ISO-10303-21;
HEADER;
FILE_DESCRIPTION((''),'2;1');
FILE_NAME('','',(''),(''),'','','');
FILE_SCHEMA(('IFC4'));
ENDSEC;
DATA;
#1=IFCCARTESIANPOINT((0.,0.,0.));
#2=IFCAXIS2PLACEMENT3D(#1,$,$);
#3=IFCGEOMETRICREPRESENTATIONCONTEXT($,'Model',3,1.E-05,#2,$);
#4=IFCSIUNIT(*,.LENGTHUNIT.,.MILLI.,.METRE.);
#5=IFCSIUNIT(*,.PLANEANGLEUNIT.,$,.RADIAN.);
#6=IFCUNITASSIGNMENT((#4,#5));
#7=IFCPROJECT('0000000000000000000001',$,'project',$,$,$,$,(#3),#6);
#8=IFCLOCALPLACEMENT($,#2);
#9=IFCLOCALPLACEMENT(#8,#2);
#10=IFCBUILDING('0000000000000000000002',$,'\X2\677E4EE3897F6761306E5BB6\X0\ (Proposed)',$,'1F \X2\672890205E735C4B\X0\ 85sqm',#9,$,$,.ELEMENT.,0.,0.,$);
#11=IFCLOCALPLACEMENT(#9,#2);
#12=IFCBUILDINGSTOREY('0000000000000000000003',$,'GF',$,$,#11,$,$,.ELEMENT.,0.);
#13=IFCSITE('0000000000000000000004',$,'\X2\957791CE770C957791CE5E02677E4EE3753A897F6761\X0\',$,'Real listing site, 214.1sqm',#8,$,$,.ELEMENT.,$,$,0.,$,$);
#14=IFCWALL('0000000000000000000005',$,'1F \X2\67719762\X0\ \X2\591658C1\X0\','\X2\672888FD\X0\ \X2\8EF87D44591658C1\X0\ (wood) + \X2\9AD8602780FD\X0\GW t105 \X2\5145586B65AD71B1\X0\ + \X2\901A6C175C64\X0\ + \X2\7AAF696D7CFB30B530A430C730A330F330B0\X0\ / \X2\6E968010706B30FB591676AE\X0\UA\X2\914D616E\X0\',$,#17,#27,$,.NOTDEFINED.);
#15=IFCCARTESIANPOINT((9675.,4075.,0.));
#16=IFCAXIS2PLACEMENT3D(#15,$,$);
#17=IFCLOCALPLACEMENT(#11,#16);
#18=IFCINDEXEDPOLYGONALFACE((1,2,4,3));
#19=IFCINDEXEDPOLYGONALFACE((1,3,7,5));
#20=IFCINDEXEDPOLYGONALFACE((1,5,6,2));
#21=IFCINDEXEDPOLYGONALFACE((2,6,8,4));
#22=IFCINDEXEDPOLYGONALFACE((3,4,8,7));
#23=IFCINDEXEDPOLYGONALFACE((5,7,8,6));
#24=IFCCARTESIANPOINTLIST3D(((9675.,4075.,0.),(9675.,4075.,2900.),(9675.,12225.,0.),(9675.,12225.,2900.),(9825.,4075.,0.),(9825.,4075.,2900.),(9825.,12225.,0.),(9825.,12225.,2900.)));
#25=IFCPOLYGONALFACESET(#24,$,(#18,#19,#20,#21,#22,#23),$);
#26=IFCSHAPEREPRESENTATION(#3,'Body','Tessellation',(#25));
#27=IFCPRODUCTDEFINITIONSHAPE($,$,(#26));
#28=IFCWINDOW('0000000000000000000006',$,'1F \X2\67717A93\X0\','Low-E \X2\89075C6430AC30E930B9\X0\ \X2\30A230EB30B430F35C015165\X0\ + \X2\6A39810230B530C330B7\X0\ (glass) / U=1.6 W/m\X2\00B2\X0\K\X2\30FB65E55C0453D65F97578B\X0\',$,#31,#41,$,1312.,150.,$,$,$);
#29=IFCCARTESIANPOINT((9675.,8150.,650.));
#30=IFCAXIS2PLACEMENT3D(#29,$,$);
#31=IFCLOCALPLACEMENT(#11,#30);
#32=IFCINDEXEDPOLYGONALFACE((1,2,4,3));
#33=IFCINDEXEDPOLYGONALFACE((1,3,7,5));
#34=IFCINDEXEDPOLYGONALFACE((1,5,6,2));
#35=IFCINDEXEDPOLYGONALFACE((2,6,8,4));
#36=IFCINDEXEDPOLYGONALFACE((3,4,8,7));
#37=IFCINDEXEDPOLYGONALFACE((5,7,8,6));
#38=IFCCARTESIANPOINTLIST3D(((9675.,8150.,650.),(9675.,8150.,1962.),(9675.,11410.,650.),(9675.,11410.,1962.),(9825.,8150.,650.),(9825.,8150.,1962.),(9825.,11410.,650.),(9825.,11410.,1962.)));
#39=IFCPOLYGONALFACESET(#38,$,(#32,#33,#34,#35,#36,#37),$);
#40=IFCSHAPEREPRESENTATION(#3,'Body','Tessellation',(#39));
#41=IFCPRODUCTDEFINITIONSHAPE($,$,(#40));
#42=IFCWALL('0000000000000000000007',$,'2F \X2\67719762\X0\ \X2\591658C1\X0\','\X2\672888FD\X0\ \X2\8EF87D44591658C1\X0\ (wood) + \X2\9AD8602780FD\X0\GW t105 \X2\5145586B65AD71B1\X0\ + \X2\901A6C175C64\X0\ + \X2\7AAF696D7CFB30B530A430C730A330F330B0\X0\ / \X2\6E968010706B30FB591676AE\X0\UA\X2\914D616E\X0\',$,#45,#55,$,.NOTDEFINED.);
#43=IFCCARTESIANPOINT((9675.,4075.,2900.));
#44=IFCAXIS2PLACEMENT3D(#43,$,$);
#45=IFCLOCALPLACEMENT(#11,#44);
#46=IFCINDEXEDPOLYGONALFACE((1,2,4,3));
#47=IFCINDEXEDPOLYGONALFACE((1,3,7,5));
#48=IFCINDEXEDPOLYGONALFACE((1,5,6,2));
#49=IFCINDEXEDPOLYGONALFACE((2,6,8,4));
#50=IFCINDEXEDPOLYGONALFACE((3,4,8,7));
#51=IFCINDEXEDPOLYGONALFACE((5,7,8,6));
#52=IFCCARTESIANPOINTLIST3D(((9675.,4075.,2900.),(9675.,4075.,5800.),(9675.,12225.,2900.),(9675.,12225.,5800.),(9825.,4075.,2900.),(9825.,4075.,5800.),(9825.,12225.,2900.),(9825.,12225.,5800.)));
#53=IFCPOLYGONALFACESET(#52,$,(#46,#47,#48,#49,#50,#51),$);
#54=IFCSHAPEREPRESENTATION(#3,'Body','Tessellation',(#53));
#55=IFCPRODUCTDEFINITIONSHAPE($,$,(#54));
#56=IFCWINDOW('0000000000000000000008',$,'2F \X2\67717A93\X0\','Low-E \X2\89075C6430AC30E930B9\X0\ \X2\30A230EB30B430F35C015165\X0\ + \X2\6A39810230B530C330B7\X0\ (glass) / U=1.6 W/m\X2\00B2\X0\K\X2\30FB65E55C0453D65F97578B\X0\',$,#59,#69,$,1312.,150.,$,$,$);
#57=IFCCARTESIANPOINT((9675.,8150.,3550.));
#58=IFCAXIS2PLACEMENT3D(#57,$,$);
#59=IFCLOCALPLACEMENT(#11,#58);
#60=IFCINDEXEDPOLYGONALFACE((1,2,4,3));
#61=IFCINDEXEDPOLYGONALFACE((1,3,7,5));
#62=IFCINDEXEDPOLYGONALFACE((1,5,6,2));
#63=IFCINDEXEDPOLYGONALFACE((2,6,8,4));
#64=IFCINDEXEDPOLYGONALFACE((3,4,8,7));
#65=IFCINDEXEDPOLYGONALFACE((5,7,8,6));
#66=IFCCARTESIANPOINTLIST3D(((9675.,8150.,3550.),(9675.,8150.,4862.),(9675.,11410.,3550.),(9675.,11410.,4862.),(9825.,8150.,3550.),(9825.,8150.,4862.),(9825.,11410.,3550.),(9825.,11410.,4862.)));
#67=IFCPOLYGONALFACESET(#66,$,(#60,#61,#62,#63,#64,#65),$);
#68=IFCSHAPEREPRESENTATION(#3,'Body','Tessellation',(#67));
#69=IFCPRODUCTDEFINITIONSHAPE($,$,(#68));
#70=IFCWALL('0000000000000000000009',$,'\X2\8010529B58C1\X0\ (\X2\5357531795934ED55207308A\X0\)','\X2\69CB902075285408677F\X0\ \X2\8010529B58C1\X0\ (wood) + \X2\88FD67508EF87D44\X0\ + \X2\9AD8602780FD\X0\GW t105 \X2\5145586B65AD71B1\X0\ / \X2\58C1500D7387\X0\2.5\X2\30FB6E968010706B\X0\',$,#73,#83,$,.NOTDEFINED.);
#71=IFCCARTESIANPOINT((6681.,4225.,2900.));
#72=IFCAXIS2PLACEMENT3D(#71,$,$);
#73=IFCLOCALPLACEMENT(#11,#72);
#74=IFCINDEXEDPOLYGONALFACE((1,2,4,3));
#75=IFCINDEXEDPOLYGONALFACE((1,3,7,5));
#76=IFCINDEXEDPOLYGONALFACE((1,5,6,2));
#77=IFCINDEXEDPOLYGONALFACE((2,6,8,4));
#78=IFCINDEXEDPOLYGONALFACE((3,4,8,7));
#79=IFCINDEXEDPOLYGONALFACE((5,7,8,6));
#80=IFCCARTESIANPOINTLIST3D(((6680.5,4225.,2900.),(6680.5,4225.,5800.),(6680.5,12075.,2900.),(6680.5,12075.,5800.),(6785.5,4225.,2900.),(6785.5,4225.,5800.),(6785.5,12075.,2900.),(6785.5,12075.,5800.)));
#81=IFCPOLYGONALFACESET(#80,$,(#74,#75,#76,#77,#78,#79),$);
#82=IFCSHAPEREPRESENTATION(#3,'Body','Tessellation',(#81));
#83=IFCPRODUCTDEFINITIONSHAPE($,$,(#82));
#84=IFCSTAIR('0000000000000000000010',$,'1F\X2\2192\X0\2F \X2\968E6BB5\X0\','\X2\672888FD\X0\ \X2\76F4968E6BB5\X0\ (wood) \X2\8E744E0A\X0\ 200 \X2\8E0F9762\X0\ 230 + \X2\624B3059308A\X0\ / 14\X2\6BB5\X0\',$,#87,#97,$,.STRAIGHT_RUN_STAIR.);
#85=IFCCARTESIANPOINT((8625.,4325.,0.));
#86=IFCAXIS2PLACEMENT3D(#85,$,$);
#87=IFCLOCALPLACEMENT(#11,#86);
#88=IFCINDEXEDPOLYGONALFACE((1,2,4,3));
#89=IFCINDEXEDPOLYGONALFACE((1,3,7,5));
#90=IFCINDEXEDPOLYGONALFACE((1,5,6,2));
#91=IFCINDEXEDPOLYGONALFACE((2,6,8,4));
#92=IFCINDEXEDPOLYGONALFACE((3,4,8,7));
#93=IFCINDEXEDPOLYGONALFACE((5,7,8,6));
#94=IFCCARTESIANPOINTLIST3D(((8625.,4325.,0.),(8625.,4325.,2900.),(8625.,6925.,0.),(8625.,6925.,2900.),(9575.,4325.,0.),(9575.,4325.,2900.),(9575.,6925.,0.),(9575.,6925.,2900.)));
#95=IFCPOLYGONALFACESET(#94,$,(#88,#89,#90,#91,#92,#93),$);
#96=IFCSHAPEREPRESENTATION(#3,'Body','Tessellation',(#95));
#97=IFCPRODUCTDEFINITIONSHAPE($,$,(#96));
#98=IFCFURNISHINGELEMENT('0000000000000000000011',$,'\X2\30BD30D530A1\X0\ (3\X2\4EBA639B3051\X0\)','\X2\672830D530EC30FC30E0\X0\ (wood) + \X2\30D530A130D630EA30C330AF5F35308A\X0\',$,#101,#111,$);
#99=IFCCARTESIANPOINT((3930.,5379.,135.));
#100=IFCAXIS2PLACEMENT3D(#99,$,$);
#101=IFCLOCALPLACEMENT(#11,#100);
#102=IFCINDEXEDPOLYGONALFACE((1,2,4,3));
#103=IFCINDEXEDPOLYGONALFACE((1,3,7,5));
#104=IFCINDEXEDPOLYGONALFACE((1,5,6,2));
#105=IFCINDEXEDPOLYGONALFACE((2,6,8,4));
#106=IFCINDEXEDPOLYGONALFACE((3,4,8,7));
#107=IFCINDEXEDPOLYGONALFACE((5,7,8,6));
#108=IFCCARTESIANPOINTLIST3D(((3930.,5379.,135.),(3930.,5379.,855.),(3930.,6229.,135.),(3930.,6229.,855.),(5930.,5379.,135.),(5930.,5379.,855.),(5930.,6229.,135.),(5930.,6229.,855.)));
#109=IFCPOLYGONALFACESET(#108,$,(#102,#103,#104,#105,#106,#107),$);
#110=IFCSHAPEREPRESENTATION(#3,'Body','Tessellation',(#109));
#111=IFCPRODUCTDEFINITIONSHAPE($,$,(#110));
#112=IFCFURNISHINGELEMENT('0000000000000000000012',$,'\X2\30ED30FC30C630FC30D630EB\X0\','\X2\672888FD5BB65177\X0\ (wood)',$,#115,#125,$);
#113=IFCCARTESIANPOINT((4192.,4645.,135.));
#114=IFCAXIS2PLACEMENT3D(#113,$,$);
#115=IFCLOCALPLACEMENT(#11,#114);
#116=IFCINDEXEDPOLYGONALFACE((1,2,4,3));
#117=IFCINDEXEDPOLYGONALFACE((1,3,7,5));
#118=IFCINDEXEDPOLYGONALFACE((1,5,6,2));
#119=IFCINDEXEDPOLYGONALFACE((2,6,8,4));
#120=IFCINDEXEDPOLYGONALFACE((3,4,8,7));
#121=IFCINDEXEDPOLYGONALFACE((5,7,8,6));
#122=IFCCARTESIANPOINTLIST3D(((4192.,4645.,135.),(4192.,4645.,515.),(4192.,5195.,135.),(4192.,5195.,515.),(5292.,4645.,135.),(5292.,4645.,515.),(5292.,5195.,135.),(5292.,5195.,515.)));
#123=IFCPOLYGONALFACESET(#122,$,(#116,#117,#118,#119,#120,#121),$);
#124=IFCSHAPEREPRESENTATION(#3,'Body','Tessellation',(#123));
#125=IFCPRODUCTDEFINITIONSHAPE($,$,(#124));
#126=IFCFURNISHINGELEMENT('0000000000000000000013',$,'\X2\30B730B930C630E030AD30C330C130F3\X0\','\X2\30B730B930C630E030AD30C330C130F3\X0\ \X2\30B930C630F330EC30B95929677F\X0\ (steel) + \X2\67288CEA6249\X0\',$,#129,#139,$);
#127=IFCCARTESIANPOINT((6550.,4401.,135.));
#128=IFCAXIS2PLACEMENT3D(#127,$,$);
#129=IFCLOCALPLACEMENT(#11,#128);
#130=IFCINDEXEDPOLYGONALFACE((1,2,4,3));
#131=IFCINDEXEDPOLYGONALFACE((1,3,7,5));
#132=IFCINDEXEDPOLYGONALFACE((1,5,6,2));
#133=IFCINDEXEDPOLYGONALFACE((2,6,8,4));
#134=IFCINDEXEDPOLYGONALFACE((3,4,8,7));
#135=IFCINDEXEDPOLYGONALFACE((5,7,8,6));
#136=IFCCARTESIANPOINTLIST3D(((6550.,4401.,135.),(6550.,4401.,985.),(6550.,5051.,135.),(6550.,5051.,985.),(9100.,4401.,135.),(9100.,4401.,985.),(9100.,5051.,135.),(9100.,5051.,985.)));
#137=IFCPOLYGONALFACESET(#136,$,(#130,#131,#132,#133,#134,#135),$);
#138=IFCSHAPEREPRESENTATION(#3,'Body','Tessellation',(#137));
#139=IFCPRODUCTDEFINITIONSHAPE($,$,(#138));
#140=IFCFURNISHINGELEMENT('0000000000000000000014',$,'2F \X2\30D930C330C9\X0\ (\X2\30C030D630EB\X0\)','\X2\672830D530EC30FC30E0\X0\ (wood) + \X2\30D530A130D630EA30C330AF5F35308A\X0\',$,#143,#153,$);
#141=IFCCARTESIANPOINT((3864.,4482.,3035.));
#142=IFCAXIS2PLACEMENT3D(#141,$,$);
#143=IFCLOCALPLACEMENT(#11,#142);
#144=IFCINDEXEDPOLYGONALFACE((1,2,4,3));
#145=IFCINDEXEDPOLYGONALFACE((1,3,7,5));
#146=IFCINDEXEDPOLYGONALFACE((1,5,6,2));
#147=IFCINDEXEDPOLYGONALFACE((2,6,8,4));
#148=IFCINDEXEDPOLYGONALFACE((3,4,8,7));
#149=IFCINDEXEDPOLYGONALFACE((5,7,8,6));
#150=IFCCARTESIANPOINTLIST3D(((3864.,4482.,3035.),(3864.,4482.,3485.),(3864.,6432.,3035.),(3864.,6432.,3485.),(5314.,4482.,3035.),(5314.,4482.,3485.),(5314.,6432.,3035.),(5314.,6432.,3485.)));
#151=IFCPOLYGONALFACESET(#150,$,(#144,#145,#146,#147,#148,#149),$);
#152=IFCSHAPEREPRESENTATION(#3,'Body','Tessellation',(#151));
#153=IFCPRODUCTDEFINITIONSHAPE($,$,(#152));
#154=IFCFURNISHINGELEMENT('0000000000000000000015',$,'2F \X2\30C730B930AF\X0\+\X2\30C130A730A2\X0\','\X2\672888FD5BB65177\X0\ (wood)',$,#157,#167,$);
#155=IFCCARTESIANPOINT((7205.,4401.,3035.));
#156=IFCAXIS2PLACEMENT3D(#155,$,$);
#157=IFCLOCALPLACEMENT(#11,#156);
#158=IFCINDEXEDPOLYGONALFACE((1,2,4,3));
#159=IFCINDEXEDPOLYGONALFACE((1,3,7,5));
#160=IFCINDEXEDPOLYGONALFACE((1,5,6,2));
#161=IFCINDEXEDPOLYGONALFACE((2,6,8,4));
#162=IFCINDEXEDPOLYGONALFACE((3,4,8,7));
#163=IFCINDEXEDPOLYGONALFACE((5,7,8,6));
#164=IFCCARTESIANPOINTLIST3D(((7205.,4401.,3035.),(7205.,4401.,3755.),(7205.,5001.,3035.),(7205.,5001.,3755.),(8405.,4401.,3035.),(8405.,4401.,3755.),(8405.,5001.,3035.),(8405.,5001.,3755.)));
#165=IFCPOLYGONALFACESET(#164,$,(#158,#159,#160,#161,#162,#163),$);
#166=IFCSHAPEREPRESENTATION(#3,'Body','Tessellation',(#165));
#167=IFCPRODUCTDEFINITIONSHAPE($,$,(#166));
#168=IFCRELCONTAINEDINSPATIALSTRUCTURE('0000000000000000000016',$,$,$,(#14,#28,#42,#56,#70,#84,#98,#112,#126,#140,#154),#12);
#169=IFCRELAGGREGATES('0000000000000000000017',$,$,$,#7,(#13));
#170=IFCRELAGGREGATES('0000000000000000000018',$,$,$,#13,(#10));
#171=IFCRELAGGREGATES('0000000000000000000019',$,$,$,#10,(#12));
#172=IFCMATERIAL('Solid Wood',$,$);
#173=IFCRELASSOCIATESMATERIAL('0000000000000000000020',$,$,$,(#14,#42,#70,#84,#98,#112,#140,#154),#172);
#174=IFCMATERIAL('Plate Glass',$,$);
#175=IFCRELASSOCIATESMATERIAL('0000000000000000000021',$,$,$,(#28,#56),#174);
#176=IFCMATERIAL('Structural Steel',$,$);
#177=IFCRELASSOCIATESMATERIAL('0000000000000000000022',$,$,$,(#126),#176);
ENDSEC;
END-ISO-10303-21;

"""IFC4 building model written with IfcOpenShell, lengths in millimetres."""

from ifc_helpers import new_model, si_unit, frame, frame_2d, origin, place, context, project, spatial, rectangle, extrude, material, element, fill, save


model = new_model("IFC4")

# Units and contexts
model_context = context("Model", 3, precision=1e-05, world=origin())
ifc_project = project(units=[si_unit("LENGTHUNIT", "METRE", prefix="MILLI"), si_unit("PLANEANGLEUNIT", "RADIAN")], contexts=[model_context])

# Site, building, storey
site_placement = place(None, origin())
site = spatial("IfcSite", under=ifc_project, at=site_placement, Name="長野県長野市松代町西条", ObjectType="Real listing site, 214.1sqm", CompositionType="ELEMENT", RefElevation=0.0)
building_placement = place(site_placement, origin())
building = spatial("IfcBuilding", under=site, at=building_placement, Name="松代西条の家 (Proposed)", ObjectType="1F 木造平屋 85sqm", CompositionType="ELEMENT", ElevationOfRefHeight=0.0, ElevationOfTerrain=0.0)
storey_placement = place(building_placement, origin())
storey = spatial("IfcBuildingStorey", under=building, at=storey_placement, Name="GF", CompositionType="ELEMENT", Elevation=0.0)

# Wall, opening, window
ifc_material_1 = material(Name="Solid Wood")
wall_1_placement = place(storey_placement, frame((9675.0, 4075.0, 0.0)))
wall_1 = element("IfcWall", 1, at=wall_1_placement, inside=storey, material=ifc_material_1, Name="1F 東面 外壁", Description="木製 軸組外壁 (wood) + 高性能GW t105 充填断熱 + 通気層 + 窯業系サイディング / 準耐火・外皮UA配慮", PredefinedType="NOTDEFINED", context=model_context, shape_type="SweptSolid", body=[
    extrude(rectangle(XDim=150.0, YDim=8150.0, at=frame_2d((75.0, 4075.0))), frame((9675.0, 4075.0, 0.0)), (0.0, 0.0, 1.0), 2900.0),
])
opening_1_placement = place(storey_placement, frame((9675.0, 8150.0, 650.0)))
opening_1 = element("IfcOpeningElement", 2, at=opening_1_placement, cuts=wall_1, PredefinedType="NOTDEFINED", context=model_context, shape_type="SweptSolid", body=[
    extrude(rectangle(XDim=150.0, YDim=3260.0, at=frame_2d((75.0, 1630.0))), frame((9675.0, 8150.0, 650.0)), (0.0, 0.0, 1.0), 1312.0),
])
ifc_material_2 = material(Name="Plate Glass")
window_1_placement = place(storey_placement, frame((9675.0, 8150.0, 650.0)))
window_1 = element("IfcWindow", 3, at=window_1_placement, inside=storey, material=ifc_material_2, Name="1F 東窓", Description="Low-E 複層ガラス アルゴン封入 + 樹脂サッシ (glass) / U=1.6 W/m²K・日射取得型", OverallHeight=1312.0, OverallWidth=150.0, context=model_context, shape_type="SweptSolid", body=[
    extrude(rectangle(XDim=150.0, YDim=3260.0, at=frame_2d((75.0, 1630.0))), frame((9675.0, 8150.0, 650.0)), (0.0, 0.0, 1.0), 1312.0),
])
fill(opening_1, window_1)

# Wall, opening, window
wall_2_placement = place(storey_placement, frame((9675.0, 4075.0, 2900.0)))
wall_2 = element("IfcWall", 4, at=wall_2_placement, inside=storey, material=ifc_material_1, Name="2F 東面 外壁", Description="木製 軸組外壁 (wood) + 高性能GW t105 充填断熱 + 通気層 + 窯業系サイディング / 準耐火・外皮UA配慮", PredefinedType="NOTDEFINED", context=model_context, shape_type="SweptSolid", body=[
    extrude(rectangle(XDim=150.0, YDim=8150.0, at=frame_2d((75.0, 4075.0))), frame((9675.0, 4075.0, 2900.0)), (0.0, 0.0, 1.0), 2900.0),
])
opening_2_placement = place(storey_placement, frame((9675.0, 8150.0, 3550.0)))
opening_2 = element("IfcOpeningElement", 5, at=opening_2_placement, cuts=wall_2, PredefinedType="NOTDEFINED", context=model_context, shape_type="SweptSolid", body=[
    extrude(rectangle(XDim=150.0, YDim=3260.0, at=frame_2d((75.0, 1630.0))), frame((9675.0, 8150.0, 3550.0)), (0.0, 0.0, 1.0), 1312.0),
])
window_2_placement = place(storey_placement, frame((9675.0, 8150.0, 3550.0)))
window_2 = element("IfcWindow", 6, at=window_2_placement, inside=storey, material=ifc_material_2, Name="2F 東窓", Description="Low-E 複層ガラス アルゴン封入 + 樹脂サッシ (glass) / U=1.6 W/m²K・日射取得型", OverallHeight=1312.0, OverallWidth=150.0, context=model_context, shape_type="SweptSolid", body=[
    extrude(rectangle(XDim=150.0, YDim=3260.0, at=frame_2d((75.0, 1630.0))), frame((9675.0, 8150.0, 3550.0)), (0.0, 0.0, 1.0), 1312.0),
])
fill(opening_2, window_2)

# Wall
wall_3_placement = place(storey_placement, frame((6681.0, 4225.0, 2900.0)))
element("IfcWall", 7, at=wall_3_placement, inside=storey, material=ifc_material_1, Name="耐力壁 (南北間仕切り)", Description="構造用合板 耐力壁 (wood) + 製材軸組 + 高性能GW t105 充填断熱 / 壁倍率2.5・準耐火", PredefinedType="NOTDEFINED", context=model_context, shape_type="SweptSolid", body=[
    extrude(rectangle(XDim=105.0, YDim=7850.0, at=frame_2d((52.0, 3925.0))), frame((6681.0, 4225.0, 2900.0)), (0.0, 0.0, 1.0), 2900.0),
])

# Stair
stair_placement = place(storey_placement, frame((8625.0, 4325.0, 0.0)))
element("IfcStair", 8, at=stair_placement, inside=storey, material=ifc_material_1, Name="1F→2F 階段", Description="木製 直階段 (wood) 蹴上 200 踏面 230 + 手すり / 14段", PredefinedType="STRAIGHT_RUN_STAIR", context=model_context, shape_type="SweptSolid", body=[
    extrude(rectangle(XDim=950.0, YDim=2600.0, at=frame_2d((475.0, 1300.0))), frame((8625.0, 4325.0, 0.0)), (0.0, 0.0, 1.0), 2900.0),
])

# Furnishing elements
furnishing_1_placement = place(storey_placement, frame((3930.0, 5379.0, 135.0)))
element("IfcFurnishingElement", 9, at=furnishing_1_placement, inside=storey, material=ifc_material_1, Name="ソファ (3人掛け)", Description="木フレーム (wood) + ファブリック張り", context=model_context, shape_type="SweptSolid", body=[
    extrude(rectangle(XDim=2000.0, YDim=850.0, at=frame_2d((1000.0, 425.0))), frame((3930.0, 5379.0, 135.0)), (0.0, 0.0, 1.0), 720.0),
])
furnishing_2_placement = place(storey_placement, frame((4192.0, 4645.0, 135.0)))
element("IfcFurnishingElement", 10, at=furnishing_2_placement, inside=storey, material=ifc_material_1, Name="ローテーブル", Description="木製家具 (wood)", context=model_context, shape_type="SweptSolid", body=[
    extrude(rectangle(XDim=1100.0, YDim=550.0, at=frame_2d((550.0, 275.0))), frame((4192.0, 4645.0, 135.0)), (0.0, 0.0, 1.0), 380.0),
])
ifc_material_3 = material(Name="Structural Steel")
furnishing_3_placement = place(storey_placement, frame((6550.0, 4401.0, 135.0)))
element("IfcFurnishingElement", 11, at=furnishing_3_placement, inside=storey, material=ifc_material_3, Name="システムキッチン", Description="システムキッチン ステンレス天板 (steel) + 木質扉", context=model_context, shape_type="SweptSolid", body=[
    extrude(rectangle(XDim=2550.0, YDim=650.0, at=frame_2d((1275.0, 325.0))), frame((6550.0, 4401.0, 135.0)), (0.0, 0.0, 1.0), 850.0),
])
furnishing_4_placement = place(storey_placement, frame((3864.0, 4482.0, 3035.0)))
element("IfcFurnishingElement", 12, at=furnishing_4_placement, inside=storey, material=ifc_material_1, Name="2F ベッド (ダブル)", Description="木フレーム (wood) + ファブリック張り", context=model_context, shape_type="SweptSolid", body=[
    extrude(rectangle(XDim=1450.0, YDim=1950.0, at=frame_2d((725.0, 975.0))), frame((3864.0, 4482.0, 3035.0)), (0.0, 0.0, 1.0), 450.0),
])
furnishing_5_placement = place(storey_placement, frame((7205.0, 4401.0, 3035.0)))
element("IfcFurnishingElement", 13, at=furnishing_5_placement, inside=storey, material=ifc_material_1, Name="2F デスク+チェア", Description="木製家具 (wood)", context=model_context, shape_type="SweptSolid", body=[
    extrude(rectangle(XDim=1200.0, YDim=600.0, at=frame_2d((600.0, 300.0))), frame((7205.0, 4401.0, 3035.0)), (0.0, 0.0, 1.0), 720.0),
])

save(model, "model.ifc")
